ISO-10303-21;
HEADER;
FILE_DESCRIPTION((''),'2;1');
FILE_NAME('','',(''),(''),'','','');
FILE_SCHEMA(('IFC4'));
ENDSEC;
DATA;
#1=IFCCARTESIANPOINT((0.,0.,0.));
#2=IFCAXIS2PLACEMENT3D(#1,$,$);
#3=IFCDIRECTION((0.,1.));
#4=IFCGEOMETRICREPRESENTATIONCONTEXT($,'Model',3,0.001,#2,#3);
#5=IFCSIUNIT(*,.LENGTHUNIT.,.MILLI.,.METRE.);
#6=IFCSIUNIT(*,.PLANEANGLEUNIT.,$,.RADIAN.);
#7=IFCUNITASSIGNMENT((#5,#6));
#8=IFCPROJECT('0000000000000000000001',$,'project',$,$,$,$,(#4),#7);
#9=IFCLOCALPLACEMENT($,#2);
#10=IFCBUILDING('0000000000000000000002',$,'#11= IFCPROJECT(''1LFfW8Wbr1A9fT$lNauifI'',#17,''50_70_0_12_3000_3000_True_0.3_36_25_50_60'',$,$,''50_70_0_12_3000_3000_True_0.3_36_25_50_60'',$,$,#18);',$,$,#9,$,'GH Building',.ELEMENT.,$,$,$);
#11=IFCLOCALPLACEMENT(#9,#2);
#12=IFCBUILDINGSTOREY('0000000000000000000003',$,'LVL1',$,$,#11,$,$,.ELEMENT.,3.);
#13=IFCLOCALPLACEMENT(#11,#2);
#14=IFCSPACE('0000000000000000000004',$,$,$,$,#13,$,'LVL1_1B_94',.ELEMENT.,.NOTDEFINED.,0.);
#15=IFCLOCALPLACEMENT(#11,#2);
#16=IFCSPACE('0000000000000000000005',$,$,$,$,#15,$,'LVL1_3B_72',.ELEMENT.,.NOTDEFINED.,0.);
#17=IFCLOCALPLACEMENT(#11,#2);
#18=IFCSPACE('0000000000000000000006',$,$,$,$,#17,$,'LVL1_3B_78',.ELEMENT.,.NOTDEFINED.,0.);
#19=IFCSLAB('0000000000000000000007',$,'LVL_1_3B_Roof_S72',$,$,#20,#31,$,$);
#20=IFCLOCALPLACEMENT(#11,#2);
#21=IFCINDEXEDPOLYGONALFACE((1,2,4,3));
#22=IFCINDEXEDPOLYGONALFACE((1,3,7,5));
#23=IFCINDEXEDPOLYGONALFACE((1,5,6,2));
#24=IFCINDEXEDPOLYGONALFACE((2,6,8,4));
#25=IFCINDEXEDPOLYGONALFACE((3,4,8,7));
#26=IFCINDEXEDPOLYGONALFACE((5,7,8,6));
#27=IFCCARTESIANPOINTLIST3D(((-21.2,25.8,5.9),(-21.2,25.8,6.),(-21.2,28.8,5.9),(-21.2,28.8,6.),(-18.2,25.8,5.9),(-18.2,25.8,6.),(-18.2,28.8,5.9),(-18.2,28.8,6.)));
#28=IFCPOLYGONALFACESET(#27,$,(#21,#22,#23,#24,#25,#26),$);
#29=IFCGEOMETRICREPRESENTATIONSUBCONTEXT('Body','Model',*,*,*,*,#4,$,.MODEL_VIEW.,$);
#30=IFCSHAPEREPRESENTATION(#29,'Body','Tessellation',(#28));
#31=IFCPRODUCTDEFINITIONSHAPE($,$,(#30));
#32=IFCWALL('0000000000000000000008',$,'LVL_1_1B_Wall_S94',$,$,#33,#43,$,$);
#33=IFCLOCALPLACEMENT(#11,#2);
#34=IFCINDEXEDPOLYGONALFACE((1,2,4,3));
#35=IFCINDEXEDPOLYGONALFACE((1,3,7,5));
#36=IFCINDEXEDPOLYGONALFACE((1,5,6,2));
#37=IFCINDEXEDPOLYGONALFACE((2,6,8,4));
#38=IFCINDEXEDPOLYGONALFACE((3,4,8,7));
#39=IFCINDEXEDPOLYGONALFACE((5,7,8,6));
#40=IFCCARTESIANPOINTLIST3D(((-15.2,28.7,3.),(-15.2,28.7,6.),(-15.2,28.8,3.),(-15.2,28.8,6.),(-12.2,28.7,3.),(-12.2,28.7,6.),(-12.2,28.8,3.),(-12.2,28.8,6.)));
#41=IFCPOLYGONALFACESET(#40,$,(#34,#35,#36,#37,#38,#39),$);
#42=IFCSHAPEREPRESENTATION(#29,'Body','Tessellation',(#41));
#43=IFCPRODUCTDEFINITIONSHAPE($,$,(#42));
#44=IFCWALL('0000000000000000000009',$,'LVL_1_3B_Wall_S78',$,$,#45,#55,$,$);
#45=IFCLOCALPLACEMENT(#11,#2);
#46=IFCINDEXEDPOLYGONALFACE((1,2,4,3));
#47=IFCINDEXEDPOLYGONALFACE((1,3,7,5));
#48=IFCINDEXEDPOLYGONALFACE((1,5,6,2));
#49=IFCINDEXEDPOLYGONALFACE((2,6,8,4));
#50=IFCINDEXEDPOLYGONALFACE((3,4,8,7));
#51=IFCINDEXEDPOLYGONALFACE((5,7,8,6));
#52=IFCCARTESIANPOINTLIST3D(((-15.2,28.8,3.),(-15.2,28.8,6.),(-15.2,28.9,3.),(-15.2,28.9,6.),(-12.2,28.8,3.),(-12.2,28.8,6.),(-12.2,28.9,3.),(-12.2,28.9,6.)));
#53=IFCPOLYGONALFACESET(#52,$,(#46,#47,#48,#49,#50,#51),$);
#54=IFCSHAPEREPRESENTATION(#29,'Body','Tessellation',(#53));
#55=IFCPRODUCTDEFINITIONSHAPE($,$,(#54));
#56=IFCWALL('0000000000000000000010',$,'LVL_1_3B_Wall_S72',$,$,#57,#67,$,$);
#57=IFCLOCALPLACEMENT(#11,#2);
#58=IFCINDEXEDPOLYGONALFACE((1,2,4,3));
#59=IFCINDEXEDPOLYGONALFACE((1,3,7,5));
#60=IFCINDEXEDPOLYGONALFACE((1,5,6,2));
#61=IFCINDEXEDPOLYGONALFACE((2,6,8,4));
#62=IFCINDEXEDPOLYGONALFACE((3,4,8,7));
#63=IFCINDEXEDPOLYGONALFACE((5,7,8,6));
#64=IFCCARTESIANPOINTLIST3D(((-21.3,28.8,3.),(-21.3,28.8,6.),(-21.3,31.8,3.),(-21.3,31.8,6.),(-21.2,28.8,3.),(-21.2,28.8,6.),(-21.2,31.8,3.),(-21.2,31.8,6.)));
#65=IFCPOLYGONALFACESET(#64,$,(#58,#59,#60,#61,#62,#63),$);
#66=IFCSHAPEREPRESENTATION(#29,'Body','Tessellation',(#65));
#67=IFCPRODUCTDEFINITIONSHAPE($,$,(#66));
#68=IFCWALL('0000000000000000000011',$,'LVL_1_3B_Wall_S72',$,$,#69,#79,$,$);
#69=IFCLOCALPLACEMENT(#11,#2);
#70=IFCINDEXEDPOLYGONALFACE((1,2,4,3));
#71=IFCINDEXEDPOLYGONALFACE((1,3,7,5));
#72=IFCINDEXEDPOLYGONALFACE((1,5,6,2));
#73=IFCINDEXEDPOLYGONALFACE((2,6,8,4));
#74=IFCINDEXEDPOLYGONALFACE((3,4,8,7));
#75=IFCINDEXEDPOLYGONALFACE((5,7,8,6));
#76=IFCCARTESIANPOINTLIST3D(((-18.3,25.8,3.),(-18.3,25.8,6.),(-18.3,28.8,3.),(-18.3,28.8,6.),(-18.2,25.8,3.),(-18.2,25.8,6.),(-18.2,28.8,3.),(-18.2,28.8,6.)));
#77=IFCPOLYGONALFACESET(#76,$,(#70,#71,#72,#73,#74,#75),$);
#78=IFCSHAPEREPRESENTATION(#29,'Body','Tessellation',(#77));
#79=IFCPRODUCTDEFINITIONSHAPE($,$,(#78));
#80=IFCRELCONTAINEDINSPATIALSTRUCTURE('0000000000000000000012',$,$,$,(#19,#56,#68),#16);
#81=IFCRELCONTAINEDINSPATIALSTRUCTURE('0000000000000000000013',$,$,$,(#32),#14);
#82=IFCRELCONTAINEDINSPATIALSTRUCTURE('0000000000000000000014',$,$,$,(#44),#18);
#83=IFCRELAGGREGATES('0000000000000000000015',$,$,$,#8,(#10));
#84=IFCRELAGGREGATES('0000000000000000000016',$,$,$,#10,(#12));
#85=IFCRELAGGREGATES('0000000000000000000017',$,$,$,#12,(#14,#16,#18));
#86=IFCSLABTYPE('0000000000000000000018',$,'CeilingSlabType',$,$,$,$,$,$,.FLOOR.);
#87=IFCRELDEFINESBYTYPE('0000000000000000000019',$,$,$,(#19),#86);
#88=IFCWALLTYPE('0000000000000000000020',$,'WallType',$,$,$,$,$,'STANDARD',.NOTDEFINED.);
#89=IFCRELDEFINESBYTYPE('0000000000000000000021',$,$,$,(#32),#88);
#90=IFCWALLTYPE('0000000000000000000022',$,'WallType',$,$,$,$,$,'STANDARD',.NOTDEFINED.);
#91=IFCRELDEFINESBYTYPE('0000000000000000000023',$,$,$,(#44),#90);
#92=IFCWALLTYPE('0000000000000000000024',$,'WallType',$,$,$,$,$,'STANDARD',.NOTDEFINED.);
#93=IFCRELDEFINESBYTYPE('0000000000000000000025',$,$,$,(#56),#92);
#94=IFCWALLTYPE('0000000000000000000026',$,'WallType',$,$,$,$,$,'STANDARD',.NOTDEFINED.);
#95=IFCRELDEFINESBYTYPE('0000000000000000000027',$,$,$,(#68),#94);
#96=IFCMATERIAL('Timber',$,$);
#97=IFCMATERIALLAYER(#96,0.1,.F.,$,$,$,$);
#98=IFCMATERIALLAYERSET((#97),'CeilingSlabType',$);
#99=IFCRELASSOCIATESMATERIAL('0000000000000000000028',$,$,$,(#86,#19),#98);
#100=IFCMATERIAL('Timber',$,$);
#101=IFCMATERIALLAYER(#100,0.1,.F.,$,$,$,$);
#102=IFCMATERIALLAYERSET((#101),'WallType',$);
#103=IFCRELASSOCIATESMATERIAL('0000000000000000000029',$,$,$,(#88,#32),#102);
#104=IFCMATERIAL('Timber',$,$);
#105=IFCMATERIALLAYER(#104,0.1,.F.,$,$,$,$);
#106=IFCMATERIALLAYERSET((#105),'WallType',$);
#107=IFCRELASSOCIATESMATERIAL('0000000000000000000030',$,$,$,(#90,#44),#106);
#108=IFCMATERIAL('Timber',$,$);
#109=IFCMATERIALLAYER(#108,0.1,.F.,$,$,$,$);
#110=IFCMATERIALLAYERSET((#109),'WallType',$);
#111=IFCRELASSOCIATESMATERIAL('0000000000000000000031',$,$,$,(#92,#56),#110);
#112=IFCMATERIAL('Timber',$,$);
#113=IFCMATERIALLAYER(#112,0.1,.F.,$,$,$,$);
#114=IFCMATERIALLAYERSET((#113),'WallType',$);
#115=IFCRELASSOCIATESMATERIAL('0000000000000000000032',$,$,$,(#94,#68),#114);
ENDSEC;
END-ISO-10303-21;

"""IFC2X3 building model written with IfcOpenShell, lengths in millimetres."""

from ifc_helpers import new_model, si_unit, direction, frame, frame_2d, origin, place, context, subcontext, project, spatial, rectangle, extrude, material, layer, layer_set, layer_usage, type_object, element, save


model = new_model("IFC2X3")

# Units and contexts
model_context = context("Model", 3, precision=0.001, world=origin(), true_north=direction((0.0, 1.0)))
body_context = subcontext(model_context, "Body", "Model", "MODEL_VIEW")
ifc_project = project(units=[si_unit("LENGTHUNIT", "METRE", prefix="MILLI"), si_unit("PLANEANGLEUNIT", "RADIAN")], contexts=[model_context])

# Building, storey
building_placement = place(None, origin())
building = spatial("IfcBuilding", under=ifc_project, at=building_placement, Name="#11= IFCPROJECT('1LFfW8Wbr1A9fT$lNauifI',#17,'50_70_0_12_3000_3000_True_0.3_36_25_50_60',$,$,'50_70_0_12_3000_3000_True_0.3_36_25_50_60',$,$,#18);", LongName="GH Building", CompositionType="ELEMENT")
storey_placement = place(building_placement, origin())
storey = spatial("IfcBuildingStorey", under=building, at=storey_placement, Name="LVL1", CompositionType="ELEMENT", Elevation=3.0)

# Shared definitions
space_1_placement = place(storey_placement, origin())
space_1 = spatial("IfcSpace", under=storey, at=space_1_placement, LongName="LVL1_1B_94", CompositionType="ELEMENT", InteriorOrExteriorSpace="NOTDEFINED", ElevationWithFlooring=0.0)

# Shared definitions
space_2_placement = place(storey_placement, origin())
space_2 = spatial("IfcSpace", under=storey, at=space_2_placement, LongName="LVL1_3B_72", CompositionType="ELEMENT", InteriorOrExteriorSpace="NOTDEFINED", ElevationWithFlooring=0.0)

# Shared definitions
space_3_placement = place(storey_placement, origin())
space_3 = spatial("IfcSpace", under=storey, at=space_3_placement, LongName="LVL1_3B_78", CompositionType="ELEMENT", InteriorOrExteriorSpace="NOTDEFINED", ElevationWithFlooring=0.0)

# Slab
ifc_material_1 = material(Name="Timber")
ifc_layer_1 = layer(ifc_material_1, 0.1, ventilated=False)
ifc_layer_set_1 = layer_set([ifc_layer_1], Name="CeilingSlabType")
ifc_layer_usage_1 = layer_usage(ifc_layer_set_1, "AXIS3", "NEGATIVE", -0.1)
slab_type_1 = type_object("IfcSlabType", Name="CeilingSlabType", PredefinedType="FLOOR", material=ifc_layer_set_1)
slab_1_placement = place(space_2_placement, frame((-18.2, 28.8, 5.9), z_axis=(0.0, 0.0, 1.0), x_axis=(-1.0, 0.0, 0.0)))
element("IfcSlab", 1, at=slab_1_placement, inside=space_2, type_object=slab_type_1, material=ifc_layer_usage_1, Name="LVL_1_3B_Roof_S72", context=body_context, shape_type="SweptSolid", body=[
    extrude(rectangle(XDim=3.0, YDim=3.0, at=frame_2d((1.5, 1.5))), origin(), (0.0, 0.0, 1.0), 0.1),
])

# Wall
ifc_material_2 = material(Name="Timber")
ifc_layer_2 = layer(ifc_material_2, 0.1, ventilated=False)
ifc_layer_set_2 = layer_set([ifc_layer_2], Name="WallType")
ifc_layer_usage_2 = layer_usage(ifc_layer_set_2, "AXIS2", "NEGATIVE", 0.0)
wall_type_1 = type_object("IfcWallType", Name="WallType", ElementType="STANDARD", PredefinedType="NOTDEFINED", material=ifc_layer_set_2)
wall_1_placement = place(space_1_placement, frame((-15.2, 28.8, 3.0)))
element("IfcWall", 2, at=wall_1_placement, inside=space_1, type_object=wall_type_1, material=ifc_layer_usage_2, Name="LVL_1_1B_Wall_S94", context=body_context, shape_type="SweptSolid", body=[
    extrude(rectangle(XDim=3.0, YDim=0.1, at=frame_2d((1.5, -0.1))), origin(), (0.0, 0.0, 1.0), 3.0),
])

# Walls
ifc_material_3 = material(Name="Timber")
ifc_layer_3 = layer(ifc_material_3, 0.1, ventilated=False)
ifc_layer_set_3 = layer_set([ifc_layer_3], Name="WallType")
ifc_layer_usage_3 = layer_usage(ifc_layer_set_3, "AXIS2", "NEGATIVE", 0.0)
wall_type_2 = type_object("IfcWallType", Name="WallType", ElementType="STANDARD", PredefinedType="NOTDEFINED", material=ifc_layer_set_3)
wall_2_placement = place(space_3_placement, frame((-12.2, 28.8, 3.0), z_axis=(0.0, 0.0, 1.0), x_axis=(-1.0, 0.0, 0.0)))
element("IfcWall", 3, at=wall_2_placement, inside=space_3, type_object=wall_type_2, material=ifc_layer_usage_3, Name="LVL_1_3B_Wall_S78", context=body_context, shape_type="SweptSolid", body=[
    extrude(rectangle(XDim=3.0, YDim=0.1, at=frame_2d((1.5, -0.1))), origin(), (0.0, 0.0, 1.0), 3.0),
])
ifc_material_4 = material(Name="Timber")
ifc_layer_4 = layer(ifc_material_4, 0.1, ventilated=False)
ifc_layer_set_4 = layer_set([ifc_layer_4], Name="WallType")
ifc_layer_usage_4 = layer_usage(ifc_layer_set_4, "AXIS2", "NEGATIVE", 0.0)
wall_type_3 = type_object("IfcWallType", Name="WallType", ElementType="STANDARD", PredefinedType="NOTDEFINED", material=ifc_layer_set_4)
wall_3_placement = place(space_2_placement, frame((-21.2, 31.8, 3.0), z_axis=(0.0, 0.0, 1.0), x_axis=(0.0, -1.0, 0.0)))
element("IfcWall", 4, at=wall_3_placement, inside=space_2, type_object=wall_type_3, material=ifc_layer_usage_4, Name="LVL_1_3B_Wall_S72", context=body_context, shape_type="SweptSolid", body=[
    extrude(rectangle(XDim=3.0, YDim=0.1, at=frame_2d((1.5, -0.1))), origin(), (0.0, 0.0, 1.0), 3.0),
])
ifc_material_5 = material(Name="Timber")
ifc_layer_5 = layer(ifc_material_5, 0.1, ventilated=False)
ifc_layer_set_5 = layer_set([ifc_layer_5], Name="WallType")
ifc_layer_usage_5 = layer_usage(ifc_layer_set_5, "AXIS2", "NEGATIVE", 0.0)
wall_type_4 = type_object("IfcWallType", Name="WallType", ElementType="STANDARD", PredefinedType="NOTDEFINED", material=ifc_layer_set_5)
wall_4_placement = place(space_2_placement, frame((-18.2, 28.8, 3.0), z_axis=(0.0, 0.0, 1.0), x_axis=(0.0, -1.0, 0.0)))
element("IfcWall", 5, at=wall_4_placement, inside=space_2, type_object=wall_type_4, material=ifc_layer_usage_5, Name="LVL_1_3B_Wall_S72", context=body_context, shape_type="SweptSolid", body=[
    extrude(rectangle(XDim=3.0, YDim=0.1, at=frame_2d((1.5, -0.1))), origin(), (0.0, 0.0, 1.0), 3.0),
])

save(model, "model.ifc")
